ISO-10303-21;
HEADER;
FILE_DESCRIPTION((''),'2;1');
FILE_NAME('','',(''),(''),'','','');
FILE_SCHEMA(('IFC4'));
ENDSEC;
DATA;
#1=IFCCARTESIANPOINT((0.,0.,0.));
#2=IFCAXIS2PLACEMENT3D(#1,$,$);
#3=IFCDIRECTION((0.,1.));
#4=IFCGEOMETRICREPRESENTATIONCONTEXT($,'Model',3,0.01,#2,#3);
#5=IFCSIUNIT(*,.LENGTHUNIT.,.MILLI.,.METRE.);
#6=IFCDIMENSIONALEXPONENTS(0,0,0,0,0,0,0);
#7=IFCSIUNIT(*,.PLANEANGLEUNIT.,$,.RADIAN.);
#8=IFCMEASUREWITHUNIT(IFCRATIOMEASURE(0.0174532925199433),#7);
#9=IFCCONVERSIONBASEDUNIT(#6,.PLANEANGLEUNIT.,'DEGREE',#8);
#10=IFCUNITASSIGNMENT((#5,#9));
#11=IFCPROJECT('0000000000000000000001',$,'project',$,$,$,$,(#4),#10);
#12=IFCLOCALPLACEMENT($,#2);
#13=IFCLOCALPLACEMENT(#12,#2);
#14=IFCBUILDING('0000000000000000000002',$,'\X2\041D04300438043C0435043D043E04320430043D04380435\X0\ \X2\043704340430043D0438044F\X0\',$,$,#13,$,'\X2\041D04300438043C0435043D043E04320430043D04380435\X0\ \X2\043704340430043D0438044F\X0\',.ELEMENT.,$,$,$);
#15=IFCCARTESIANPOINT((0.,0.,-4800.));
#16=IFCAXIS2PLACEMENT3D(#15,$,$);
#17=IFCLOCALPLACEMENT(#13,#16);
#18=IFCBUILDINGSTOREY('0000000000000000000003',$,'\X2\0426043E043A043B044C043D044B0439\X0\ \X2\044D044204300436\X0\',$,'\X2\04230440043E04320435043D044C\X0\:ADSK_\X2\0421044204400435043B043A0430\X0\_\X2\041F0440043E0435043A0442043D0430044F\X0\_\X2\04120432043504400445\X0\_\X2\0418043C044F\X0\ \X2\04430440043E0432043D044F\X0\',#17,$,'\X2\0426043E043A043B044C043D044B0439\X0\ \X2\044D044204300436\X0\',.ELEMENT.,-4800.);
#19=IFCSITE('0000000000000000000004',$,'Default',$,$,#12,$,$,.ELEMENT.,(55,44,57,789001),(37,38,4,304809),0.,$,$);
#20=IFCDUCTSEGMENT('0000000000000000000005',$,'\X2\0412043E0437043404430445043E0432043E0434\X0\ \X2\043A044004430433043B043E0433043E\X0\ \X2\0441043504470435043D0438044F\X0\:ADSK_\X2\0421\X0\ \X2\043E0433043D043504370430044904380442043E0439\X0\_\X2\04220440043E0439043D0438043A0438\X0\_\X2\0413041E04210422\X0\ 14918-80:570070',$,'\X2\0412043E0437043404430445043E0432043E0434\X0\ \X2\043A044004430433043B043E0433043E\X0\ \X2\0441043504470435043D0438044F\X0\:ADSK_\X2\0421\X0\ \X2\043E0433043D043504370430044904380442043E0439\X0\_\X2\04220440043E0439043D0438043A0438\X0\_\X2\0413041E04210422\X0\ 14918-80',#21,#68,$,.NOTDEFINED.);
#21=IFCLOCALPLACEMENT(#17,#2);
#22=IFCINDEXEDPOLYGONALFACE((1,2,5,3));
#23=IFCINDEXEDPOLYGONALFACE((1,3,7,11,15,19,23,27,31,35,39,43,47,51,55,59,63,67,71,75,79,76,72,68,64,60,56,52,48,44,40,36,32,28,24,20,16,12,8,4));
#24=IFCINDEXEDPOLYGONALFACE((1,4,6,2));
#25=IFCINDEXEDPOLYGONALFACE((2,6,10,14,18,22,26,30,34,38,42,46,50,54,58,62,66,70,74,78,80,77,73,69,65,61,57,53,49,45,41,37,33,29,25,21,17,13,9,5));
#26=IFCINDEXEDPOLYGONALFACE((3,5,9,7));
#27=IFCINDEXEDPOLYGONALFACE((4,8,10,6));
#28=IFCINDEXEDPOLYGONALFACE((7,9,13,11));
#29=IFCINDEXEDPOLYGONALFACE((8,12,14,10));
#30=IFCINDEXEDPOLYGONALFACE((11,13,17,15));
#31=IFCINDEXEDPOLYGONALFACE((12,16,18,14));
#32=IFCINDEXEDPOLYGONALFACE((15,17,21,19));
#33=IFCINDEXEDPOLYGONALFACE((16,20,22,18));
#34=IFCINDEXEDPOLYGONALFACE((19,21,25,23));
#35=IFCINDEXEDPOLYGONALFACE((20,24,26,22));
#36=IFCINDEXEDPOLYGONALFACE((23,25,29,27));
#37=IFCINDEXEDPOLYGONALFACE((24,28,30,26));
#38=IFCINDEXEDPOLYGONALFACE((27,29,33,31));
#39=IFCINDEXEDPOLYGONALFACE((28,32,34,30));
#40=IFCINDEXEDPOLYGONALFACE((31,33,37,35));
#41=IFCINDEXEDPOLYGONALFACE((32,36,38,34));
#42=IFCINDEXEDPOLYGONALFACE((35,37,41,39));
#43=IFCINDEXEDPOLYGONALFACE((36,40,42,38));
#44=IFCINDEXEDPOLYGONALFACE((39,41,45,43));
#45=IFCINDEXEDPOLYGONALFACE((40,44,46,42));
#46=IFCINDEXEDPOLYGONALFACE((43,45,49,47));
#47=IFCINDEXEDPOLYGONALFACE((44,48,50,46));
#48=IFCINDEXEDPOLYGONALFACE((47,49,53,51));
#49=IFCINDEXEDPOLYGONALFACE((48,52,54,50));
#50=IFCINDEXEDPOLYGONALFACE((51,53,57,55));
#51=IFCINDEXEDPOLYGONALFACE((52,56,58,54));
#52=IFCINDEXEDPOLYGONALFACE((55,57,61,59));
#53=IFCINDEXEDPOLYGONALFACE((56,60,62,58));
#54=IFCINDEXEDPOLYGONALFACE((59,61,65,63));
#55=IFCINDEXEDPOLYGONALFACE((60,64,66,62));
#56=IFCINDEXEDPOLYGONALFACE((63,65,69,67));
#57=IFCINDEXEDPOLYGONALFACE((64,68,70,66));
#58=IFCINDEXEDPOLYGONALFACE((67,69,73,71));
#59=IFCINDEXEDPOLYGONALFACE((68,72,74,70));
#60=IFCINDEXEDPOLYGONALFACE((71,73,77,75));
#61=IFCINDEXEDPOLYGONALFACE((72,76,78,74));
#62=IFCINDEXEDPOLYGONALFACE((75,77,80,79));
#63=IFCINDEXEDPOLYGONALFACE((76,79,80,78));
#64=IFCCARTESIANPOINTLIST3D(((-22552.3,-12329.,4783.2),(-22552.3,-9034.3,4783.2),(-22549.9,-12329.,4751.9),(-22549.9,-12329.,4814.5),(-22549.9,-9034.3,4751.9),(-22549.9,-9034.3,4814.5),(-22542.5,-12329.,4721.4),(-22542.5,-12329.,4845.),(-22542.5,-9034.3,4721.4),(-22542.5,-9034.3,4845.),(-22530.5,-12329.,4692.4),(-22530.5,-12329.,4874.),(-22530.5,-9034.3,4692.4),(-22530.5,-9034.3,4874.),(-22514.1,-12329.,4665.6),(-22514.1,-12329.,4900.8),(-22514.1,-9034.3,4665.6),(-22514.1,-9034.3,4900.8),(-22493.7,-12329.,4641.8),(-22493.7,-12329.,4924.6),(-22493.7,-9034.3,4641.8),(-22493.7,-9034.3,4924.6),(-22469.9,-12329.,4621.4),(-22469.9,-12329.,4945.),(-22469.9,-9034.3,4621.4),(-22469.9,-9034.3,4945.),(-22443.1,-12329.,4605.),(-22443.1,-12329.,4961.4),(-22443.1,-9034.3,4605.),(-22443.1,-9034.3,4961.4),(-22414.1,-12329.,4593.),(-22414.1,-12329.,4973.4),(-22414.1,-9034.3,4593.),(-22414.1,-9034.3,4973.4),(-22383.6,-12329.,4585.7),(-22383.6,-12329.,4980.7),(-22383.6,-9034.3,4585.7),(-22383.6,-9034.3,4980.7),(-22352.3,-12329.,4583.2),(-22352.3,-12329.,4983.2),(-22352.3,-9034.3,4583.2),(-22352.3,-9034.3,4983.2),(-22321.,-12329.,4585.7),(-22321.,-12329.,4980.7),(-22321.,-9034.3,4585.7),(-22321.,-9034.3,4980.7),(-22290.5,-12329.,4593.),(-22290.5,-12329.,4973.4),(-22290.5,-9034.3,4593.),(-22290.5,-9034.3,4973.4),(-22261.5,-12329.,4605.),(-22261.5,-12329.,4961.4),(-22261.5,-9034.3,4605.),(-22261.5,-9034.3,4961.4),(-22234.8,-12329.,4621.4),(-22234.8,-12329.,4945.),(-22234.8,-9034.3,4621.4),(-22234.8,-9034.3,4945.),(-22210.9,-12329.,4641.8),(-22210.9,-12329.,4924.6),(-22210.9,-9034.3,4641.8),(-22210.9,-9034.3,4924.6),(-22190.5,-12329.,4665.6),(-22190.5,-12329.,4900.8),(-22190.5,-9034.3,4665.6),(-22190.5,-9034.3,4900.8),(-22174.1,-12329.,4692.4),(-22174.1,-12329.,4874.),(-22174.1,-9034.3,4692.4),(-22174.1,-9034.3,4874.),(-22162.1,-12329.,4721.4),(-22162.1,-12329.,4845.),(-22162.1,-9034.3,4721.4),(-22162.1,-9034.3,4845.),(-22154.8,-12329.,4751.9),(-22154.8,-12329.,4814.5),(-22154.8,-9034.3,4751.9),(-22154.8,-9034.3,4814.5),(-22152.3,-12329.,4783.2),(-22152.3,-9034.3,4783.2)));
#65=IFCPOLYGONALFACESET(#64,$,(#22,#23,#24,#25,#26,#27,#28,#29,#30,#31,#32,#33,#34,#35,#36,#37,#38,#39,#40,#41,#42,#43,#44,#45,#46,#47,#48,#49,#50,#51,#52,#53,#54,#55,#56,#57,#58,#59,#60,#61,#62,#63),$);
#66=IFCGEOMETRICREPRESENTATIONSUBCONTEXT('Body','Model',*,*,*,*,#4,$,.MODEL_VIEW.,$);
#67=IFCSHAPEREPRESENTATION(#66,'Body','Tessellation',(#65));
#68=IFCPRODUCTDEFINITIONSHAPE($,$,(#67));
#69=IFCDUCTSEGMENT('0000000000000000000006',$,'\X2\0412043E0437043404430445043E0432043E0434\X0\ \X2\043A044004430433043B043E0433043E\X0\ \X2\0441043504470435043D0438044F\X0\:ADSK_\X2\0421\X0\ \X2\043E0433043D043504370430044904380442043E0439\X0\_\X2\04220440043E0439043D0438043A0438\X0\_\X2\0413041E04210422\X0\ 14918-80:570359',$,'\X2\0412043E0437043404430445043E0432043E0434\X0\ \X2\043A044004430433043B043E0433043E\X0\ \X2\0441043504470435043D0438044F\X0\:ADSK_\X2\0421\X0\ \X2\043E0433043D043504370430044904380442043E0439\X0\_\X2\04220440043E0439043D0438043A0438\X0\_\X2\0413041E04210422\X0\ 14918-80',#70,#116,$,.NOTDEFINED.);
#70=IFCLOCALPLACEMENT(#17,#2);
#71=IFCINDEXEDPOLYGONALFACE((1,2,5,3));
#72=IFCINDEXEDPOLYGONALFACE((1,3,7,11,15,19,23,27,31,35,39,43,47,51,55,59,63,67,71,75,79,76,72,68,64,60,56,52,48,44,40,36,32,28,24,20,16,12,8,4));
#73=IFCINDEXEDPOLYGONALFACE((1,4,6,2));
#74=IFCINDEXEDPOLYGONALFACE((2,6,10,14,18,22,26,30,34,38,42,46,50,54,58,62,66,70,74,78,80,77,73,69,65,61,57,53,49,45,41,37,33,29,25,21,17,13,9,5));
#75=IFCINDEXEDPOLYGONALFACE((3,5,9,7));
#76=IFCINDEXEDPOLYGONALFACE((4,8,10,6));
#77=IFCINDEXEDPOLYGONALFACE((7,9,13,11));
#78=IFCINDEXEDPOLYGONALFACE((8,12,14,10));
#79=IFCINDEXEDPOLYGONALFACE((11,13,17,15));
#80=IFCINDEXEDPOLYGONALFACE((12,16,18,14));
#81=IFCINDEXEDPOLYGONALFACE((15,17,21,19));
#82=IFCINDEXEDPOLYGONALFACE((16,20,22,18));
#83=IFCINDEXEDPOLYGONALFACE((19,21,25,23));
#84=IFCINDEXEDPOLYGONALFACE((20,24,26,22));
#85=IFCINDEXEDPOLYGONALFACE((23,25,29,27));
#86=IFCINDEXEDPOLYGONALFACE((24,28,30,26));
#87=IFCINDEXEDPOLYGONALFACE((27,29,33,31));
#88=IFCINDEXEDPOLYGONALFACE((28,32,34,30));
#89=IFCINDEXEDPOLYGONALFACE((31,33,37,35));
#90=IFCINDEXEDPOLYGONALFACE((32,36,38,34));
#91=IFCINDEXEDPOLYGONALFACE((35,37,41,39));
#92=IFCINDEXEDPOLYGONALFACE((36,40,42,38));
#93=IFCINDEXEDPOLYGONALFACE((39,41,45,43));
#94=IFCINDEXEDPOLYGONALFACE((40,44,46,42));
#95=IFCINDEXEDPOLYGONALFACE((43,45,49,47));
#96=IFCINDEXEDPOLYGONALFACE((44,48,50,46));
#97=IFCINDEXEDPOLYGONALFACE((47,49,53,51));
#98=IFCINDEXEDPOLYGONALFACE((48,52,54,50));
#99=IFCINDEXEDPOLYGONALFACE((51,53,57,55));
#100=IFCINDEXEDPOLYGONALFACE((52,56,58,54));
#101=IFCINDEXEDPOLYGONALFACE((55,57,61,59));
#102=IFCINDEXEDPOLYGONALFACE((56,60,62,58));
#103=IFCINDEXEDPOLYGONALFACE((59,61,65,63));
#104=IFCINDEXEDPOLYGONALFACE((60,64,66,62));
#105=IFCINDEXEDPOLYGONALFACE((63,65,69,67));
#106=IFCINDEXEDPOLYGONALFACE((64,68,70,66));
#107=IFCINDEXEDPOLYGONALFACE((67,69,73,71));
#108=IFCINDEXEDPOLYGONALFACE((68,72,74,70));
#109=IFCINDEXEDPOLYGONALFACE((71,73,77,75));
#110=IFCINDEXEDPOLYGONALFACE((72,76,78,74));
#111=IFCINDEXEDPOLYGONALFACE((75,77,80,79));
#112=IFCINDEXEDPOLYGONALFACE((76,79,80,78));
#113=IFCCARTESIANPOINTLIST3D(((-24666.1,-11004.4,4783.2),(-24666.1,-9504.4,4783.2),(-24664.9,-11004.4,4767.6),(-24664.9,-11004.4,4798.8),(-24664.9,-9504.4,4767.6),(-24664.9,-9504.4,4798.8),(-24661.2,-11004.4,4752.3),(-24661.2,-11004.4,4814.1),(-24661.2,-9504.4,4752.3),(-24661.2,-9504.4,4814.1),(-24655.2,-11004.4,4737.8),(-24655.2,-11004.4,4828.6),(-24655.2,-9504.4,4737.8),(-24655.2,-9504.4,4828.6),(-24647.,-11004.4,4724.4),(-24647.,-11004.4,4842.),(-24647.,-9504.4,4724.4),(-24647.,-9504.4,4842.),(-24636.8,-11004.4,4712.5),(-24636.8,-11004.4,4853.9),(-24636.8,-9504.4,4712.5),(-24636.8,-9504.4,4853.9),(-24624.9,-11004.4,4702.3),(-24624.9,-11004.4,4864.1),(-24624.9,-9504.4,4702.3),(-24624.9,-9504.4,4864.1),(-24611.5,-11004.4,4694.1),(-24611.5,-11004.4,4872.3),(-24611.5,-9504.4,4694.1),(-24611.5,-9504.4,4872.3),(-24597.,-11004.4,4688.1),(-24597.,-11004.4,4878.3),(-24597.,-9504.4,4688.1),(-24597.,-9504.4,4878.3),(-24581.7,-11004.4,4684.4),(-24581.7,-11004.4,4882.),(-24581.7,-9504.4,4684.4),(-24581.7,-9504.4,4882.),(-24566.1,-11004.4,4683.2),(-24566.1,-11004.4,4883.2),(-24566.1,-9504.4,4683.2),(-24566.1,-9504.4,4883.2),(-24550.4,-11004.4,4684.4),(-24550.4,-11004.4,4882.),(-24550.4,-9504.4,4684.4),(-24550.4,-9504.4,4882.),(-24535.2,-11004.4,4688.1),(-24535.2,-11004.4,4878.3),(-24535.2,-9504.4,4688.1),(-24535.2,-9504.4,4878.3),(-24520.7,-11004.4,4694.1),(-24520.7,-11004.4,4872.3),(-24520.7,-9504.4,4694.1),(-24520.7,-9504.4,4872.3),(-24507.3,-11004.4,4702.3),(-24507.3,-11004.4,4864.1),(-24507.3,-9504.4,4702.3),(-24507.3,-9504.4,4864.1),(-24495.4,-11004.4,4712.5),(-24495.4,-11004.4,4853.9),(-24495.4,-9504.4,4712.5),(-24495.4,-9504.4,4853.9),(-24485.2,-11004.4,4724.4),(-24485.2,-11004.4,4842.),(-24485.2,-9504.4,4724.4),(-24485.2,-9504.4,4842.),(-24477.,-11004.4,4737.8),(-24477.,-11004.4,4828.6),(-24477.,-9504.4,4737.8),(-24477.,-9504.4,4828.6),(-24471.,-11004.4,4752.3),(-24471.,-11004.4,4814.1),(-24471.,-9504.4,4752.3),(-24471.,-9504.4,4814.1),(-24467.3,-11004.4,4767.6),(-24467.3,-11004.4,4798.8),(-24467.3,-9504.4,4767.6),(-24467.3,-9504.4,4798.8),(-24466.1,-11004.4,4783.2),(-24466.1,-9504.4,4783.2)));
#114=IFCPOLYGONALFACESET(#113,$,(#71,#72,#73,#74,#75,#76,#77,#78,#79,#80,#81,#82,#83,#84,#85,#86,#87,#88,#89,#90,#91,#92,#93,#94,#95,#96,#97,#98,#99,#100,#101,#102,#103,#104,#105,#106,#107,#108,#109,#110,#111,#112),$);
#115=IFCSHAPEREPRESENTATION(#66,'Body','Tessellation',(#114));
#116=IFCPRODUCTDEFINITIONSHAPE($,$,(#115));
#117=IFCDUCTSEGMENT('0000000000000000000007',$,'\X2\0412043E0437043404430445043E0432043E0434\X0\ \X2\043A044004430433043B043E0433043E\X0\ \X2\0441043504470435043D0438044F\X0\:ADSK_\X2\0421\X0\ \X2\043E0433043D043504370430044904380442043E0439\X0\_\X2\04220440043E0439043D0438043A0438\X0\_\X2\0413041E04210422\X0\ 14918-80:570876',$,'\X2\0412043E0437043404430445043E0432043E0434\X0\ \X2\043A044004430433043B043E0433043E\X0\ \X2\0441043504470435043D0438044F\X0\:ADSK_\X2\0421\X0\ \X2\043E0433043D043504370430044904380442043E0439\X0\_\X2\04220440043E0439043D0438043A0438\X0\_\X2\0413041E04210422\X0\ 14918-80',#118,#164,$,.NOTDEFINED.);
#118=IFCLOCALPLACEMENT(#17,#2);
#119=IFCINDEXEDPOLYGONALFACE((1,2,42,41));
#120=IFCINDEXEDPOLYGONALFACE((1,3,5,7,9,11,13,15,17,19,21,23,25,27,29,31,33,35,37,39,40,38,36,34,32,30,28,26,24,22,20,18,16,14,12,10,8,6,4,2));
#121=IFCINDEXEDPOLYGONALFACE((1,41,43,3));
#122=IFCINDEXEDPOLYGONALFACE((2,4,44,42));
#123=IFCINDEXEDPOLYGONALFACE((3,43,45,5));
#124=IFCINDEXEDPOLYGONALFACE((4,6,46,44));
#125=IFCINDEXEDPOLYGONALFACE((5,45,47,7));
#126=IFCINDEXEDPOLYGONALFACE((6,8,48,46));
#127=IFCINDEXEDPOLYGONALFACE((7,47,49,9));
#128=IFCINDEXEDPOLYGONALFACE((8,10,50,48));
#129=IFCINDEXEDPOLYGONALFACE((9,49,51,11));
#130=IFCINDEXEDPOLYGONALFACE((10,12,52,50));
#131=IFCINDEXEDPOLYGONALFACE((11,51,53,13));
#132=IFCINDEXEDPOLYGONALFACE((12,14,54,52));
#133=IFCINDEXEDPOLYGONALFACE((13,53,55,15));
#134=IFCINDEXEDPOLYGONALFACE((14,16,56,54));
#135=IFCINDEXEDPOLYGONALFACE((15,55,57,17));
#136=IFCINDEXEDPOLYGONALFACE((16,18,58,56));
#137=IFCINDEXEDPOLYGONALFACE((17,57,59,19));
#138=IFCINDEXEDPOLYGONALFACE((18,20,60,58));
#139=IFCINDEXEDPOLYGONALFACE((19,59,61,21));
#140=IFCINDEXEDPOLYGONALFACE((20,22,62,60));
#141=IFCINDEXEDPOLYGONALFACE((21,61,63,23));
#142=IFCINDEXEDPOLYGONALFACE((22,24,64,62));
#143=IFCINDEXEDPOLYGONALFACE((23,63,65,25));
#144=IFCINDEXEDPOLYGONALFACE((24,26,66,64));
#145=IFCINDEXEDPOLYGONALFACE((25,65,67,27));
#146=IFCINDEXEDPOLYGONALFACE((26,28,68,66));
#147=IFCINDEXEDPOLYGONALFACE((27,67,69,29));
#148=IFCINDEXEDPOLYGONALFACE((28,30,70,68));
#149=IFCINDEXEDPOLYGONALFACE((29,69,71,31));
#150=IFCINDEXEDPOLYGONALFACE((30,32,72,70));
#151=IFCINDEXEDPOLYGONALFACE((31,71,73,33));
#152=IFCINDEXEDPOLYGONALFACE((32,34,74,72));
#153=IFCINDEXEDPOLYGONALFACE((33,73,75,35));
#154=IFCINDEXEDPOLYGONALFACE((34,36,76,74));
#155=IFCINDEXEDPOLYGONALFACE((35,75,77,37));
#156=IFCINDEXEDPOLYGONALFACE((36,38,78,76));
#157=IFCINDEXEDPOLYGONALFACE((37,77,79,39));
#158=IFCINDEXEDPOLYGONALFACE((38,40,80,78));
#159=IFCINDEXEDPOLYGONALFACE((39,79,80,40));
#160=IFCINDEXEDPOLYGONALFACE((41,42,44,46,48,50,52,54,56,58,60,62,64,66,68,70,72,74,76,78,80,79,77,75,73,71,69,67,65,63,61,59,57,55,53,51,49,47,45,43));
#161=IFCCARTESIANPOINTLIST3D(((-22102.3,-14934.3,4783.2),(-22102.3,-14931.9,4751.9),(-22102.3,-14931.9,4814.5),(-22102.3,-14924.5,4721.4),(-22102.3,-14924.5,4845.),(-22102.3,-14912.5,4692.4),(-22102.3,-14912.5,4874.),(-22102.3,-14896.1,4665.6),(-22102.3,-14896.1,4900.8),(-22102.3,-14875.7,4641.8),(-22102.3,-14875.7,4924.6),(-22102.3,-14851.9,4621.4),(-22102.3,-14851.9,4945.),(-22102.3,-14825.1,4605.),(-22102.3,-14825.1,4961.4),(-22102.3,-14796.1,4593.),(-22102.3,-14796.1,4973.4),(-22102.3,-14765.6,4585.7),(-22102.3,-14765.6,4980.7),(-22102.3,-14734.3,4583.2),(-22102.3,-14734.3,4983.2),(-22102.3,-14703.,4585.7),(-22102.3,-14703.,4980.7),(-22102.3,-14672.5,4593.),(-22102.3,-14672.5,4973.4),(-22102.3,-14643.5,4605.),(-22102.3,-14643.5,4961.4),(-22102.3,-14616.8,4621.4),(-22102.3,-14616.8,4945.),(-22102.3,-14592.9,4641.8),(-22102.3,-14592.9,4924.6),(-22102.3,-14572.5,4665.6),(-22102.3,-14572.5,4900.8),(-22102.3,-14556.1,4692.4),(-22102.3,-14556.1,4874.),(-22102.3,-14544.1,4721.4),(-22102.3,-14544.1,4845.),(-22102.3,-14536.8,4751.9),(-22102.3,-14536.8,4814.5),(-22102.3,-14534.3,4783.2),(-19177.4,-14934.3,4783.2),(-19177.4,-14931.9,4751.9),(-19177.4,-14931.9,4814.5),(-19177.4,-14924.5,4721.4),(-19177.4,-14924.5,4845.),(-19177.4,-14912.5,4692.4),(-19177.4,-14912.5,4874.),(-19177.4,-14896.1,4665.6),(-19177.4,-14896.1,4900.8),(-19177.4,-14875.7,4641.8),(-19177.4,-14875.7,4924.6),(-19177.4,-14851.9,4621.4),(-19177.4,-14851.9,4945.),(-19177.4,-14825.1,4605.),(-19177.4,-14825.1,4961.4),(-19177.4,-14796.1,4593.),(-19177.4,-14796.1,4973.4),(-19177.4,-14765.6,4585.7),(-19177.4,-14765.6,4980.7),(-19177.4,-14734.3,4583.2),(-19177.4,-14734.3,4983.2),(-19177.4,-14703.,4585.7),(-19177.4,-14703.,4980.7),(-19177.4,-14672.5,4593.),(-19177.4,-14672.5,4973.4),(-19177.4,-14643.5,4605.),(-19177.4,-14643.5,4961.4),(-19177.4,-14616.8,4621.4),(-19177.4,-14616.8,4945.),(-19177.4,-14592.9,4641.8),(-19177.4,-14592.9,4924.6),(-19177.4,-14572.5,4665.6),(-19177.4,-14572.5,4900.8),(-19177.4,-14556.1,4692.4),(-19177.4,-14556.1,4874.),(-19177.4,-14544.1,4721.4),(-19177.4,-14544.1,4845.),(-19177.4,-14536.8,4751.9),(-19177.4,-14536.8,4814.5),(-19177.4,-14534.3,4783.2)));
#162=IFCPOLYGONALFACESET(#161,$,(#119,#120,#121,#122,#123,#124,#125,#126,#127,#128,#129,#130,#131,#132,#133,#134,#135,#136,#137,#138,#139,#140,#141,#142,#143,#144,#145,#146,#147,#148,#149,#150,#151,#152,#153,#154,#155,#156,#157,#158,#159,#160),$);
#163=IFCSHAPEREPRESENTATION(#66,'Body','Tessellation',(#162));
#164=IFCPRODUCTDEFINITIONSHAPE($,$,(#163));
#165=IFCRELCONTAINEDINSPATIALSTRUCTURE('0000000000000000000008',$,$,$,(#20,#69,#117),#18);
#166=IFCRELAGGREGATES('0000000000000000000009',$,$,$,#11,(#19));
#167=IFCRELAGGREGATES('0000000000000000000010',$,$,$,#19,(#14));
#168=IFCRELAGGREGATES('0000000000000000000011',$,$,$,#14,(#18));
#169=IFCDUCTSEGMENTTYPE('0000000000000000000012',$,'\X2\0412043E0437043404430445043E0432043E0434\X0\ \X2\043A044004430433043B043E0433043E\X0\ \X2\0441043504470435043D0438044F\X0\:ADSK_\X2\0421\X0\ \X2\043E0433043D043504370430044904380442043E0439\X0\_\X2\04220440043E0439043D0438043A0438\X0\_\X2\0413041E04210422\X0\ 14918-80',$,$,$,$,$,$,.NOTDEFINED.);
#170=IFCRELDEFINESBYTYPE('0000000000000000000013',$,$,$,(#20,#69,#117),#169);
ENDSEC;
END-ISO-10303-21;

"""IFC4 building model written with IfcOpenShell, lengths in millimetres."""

from ifc_helpers import new_model, entity, si_unit, converted_unit, direction, frame, origin, place, context, subcontext, project, spatial, indexed_curve, outline, extrude, type_object, element, save


model = new_model("IFC4")

# Units and contexts
model_context = context("Model", 3, precision=0.01, world=origin(), true_north=direction((0.0, 1.0)))
body_context = subcontext(model_context, "Body", "Model", "MODEL_VIEW")
ifc_project = project(units=[si_unit("LENGTHUNIT", "METRE", prefix="MILLI"), converted_unit("PLANEANGLEUNIT", "DEGREE", entity("IfcRatioMeasure", 0.0174532925199433), si_unit("PLANEANGLEUNIT", "RADIAN"), dimensions=[0, 0, 0, 0, 0, 0, 0])], contexts=[model_context])

# Site, building, storey
site_placement = place(None, origin())
site = spatial("IfcSite", under=ifc_project, at=site_placement, Name="Default", CompositionType="ELEMENT", RefLatitude=(55, 44, 57, 789001), RefLongitude=(37, 38, 4, 304809), RefElevation=0.0)
building_placement = place(site_placement, origin())
building = spatial("IfcBuilding", under=site, at=building_placement, Name="Наименование здания", LongName="Наименование здания", CompositionType="ELEMENT")
storey_placement = place(building_placement, frame((0.0, 0.0, -4800.0)))
storey = spatial("IfcBuildingStorey", under=building, at=storey_placement, Name="Цокльный этаж", ObjectType="Уровень:ADSK_Стрелка_Проектная_Вверх_Имя уровня", LongName="Цокльный этаж", CompositionType="ELEMENT", Elevation=-4800.0)

# Duct segments
duct_segment_type = type_object("IfcDuctSegmentType", Name="Воздуховод круглого сечения:ADSK_С огнезащитой_Тройники_ГОСТ 14918-80", PredefinedType="NOTDEFINED")
duct_segment_1_placement = place(storey_placement, origin())
element("IfcDuctSegment", 1, at=duct_segment_1_placement, inside=storey, type_object=duct_segment_type, Name="Воздуховод круглого сечения:ADSK_С огнезащитой_Тройники_ГОСТ 14918-80:570070", ObjectType="Воздуховод круглого сечения:ADSK_С огнезащитой_Тройники_ГОСТ 14918-80", PredefinedType="NOTDEFINED", context=body_context, shape_type="SweptSolid", body=[
    extrude(outline(indexed_curve([(200.0, 0.0), (197.5, 31.3), (190.2, 61.8), (178.2, 90.8), (161.8, 117.6), (141.4, 141.4), (117.6, 161.8), (90.8, 178.2), (61.8, 190.2), (31.3, 197.5), (0.0, 200.0), (-31.3, 197.5), (-61.8, 190.2), (-90.8, 178.2), (-117.6, 161.8), (-141.4, 141.4), (-161.8, 117.6), (-178.2, 90.8), (-190.2, 61.8), (-197.5, 31.3), (-200.0, 0.0), (-197.5, -31.3), (-190.2, -61.8), (-178.2, -90.8), (-161.8, -117.6), (-141.4, -141.4), (-117.6, -161.8), (-90.8, -178.2), (-61.8, -190.2), (-31.3, -197.5), (0.0, -200.0), (31.3, -197.5), (61.8, -190.2), (90.8, -178.2), (117.6, -161.8), (141.4, -141.4), (161.8, -117.6), (178.2, -90.8), (190.2, -61.8), (197.5, -31.3), (200.0, 0.0)], self_intersect=False)), frame((-22352.3, -12329.0, 4783.2), z_axis=(0.0, 1.0, 0.0), x_axis=(1.0, 0.0, 0.0)), (0.0, 0.0, 1.0), 3294.7),
])
duct_segment_2_placement = place(storey_placement, origin())
element("IfcDuctSegment", 2, at=duct_segment_2_placement, inside=storey, type_object=duct_segment_type, Name="Воздуховод круглого сечения:ADSK_С огнезащитой_Тройники_ГОСТ 14918-80:570359", ObjectType="Воздуховод круглого сечения:ADSK_С огнезащитой_Тройники_ГОСТ 14918-80", PredefinedType="NOTDEFINED", context=body_context, shape_type="SweptSolid", body=[
    extrude(outline(indexed_curve([(100.0, 0.0), (98.8, 15.6), (95.1, 30.9), (89.1, 45.4), (80.9, 58.8), (70.7, 70.7), (58.8, 80.9), (45.4, 89.1), (30.9, 95.1), (15.6, 98.8), (0.0, 100.0), (-15.6, 98.8), (-30.9, 95.1), (-45.4, 89.1), (-58.8, 80.9), (-70.7, 70.7), (-80.9, 58.8), (-89.1, 45.4), (-95.1, 30.9), (-98.8, 15.6), (-100.0, 0.0), (-98.8, -15.6), (-95.1, -30.9), (-89.1, -45.4), (-80.9, -58.8), (-70.7, -70.7), (-58.8, -80.9), (-45.4, -89.1), (-30.9, -95.1), (-15.6, -98.8), (0.0, -100.0), (15.6, -98.8), (30.9, -95.1), (45.4, -89.1), (58.8, -80.9), (70.7, -70.7), (80.9, -58.8), (89.1, -45.4), (95.1, -30.9), (98.8, -15.6), (100.0, 0.0)], self_intersect=False)), frame((-24566.1, -11004.4, 4783.2), z_axis=(0.0, 1.0, 0.0), x_axis=(1.0, 0.0, 0.0)), (0.0, 0.0, 1.0), 1500.0),
])
duct_segment_3_placement = place(storey_placement, origin())
element("IfcDuctSegment", 3, at=duct_segment_3_placement, inside=storey, type_object=duct_segment_type, Name="Воздуховод круглого сечения:ADSK_С огнезащитой_Тройники_ГОСТ 14918-80:570876", ObjectType="Воздуховод круглого сечения:ADSK_С огнезащитой_Тройники_ГОСТ 14918-80", PredefinedType="NOTDEFINED", context=body_context, shape_type="SweptSolid", body=[
    extrude(outline(indexed_curve([(200.0, 0.0), (197.5, 31.3), (190.2, 61.8), (178.2, 90.8), (161.8, 117.6), (141.4, 141.4), (117.6, 161.8), (90.8, 178.2), (61.8, 190.2), (31.3, 197.5), (0.0, 200.0), (-31.3, 197.5), (-61.8, 190.2), (-90.8, 178.2), (-117.6, 161.8), (-141.4, 141.4), (-161.8, 117.6), (-178.2, 90.8), (-190.2, 61.8), (-197.5, 31.3), (-200.0, 0.0), (-197.5, -31.3), (-190.2, -61.8), (-178.2, -90.8), (-161.8, -117.6), (-141.4, -141.4), (-117.6, -161.8), (-90.8, -178.2), (-61.8, -190.2), (-31.3, -197.5), (0.0, -200.0), (31.3, -197.5), (61.8, -190.2), (90.8, -178.2), (117.6, -161.8), (141.4, -141.4), (161.8, -117.6), (178.2, -90.8), (190.2, -61.8), (197.5, -31.3), (200.0, 0.0)], self_intersect=False)), frame((-22102.3, -14734.3, 4783.2), z_axis=(1.0, 0.0, 0.0), x_axis=(0.0, -1.0, 0.0)), (0.0, 0.0, 1.0), 2924.9),
])

save(model, "model.ifc")
